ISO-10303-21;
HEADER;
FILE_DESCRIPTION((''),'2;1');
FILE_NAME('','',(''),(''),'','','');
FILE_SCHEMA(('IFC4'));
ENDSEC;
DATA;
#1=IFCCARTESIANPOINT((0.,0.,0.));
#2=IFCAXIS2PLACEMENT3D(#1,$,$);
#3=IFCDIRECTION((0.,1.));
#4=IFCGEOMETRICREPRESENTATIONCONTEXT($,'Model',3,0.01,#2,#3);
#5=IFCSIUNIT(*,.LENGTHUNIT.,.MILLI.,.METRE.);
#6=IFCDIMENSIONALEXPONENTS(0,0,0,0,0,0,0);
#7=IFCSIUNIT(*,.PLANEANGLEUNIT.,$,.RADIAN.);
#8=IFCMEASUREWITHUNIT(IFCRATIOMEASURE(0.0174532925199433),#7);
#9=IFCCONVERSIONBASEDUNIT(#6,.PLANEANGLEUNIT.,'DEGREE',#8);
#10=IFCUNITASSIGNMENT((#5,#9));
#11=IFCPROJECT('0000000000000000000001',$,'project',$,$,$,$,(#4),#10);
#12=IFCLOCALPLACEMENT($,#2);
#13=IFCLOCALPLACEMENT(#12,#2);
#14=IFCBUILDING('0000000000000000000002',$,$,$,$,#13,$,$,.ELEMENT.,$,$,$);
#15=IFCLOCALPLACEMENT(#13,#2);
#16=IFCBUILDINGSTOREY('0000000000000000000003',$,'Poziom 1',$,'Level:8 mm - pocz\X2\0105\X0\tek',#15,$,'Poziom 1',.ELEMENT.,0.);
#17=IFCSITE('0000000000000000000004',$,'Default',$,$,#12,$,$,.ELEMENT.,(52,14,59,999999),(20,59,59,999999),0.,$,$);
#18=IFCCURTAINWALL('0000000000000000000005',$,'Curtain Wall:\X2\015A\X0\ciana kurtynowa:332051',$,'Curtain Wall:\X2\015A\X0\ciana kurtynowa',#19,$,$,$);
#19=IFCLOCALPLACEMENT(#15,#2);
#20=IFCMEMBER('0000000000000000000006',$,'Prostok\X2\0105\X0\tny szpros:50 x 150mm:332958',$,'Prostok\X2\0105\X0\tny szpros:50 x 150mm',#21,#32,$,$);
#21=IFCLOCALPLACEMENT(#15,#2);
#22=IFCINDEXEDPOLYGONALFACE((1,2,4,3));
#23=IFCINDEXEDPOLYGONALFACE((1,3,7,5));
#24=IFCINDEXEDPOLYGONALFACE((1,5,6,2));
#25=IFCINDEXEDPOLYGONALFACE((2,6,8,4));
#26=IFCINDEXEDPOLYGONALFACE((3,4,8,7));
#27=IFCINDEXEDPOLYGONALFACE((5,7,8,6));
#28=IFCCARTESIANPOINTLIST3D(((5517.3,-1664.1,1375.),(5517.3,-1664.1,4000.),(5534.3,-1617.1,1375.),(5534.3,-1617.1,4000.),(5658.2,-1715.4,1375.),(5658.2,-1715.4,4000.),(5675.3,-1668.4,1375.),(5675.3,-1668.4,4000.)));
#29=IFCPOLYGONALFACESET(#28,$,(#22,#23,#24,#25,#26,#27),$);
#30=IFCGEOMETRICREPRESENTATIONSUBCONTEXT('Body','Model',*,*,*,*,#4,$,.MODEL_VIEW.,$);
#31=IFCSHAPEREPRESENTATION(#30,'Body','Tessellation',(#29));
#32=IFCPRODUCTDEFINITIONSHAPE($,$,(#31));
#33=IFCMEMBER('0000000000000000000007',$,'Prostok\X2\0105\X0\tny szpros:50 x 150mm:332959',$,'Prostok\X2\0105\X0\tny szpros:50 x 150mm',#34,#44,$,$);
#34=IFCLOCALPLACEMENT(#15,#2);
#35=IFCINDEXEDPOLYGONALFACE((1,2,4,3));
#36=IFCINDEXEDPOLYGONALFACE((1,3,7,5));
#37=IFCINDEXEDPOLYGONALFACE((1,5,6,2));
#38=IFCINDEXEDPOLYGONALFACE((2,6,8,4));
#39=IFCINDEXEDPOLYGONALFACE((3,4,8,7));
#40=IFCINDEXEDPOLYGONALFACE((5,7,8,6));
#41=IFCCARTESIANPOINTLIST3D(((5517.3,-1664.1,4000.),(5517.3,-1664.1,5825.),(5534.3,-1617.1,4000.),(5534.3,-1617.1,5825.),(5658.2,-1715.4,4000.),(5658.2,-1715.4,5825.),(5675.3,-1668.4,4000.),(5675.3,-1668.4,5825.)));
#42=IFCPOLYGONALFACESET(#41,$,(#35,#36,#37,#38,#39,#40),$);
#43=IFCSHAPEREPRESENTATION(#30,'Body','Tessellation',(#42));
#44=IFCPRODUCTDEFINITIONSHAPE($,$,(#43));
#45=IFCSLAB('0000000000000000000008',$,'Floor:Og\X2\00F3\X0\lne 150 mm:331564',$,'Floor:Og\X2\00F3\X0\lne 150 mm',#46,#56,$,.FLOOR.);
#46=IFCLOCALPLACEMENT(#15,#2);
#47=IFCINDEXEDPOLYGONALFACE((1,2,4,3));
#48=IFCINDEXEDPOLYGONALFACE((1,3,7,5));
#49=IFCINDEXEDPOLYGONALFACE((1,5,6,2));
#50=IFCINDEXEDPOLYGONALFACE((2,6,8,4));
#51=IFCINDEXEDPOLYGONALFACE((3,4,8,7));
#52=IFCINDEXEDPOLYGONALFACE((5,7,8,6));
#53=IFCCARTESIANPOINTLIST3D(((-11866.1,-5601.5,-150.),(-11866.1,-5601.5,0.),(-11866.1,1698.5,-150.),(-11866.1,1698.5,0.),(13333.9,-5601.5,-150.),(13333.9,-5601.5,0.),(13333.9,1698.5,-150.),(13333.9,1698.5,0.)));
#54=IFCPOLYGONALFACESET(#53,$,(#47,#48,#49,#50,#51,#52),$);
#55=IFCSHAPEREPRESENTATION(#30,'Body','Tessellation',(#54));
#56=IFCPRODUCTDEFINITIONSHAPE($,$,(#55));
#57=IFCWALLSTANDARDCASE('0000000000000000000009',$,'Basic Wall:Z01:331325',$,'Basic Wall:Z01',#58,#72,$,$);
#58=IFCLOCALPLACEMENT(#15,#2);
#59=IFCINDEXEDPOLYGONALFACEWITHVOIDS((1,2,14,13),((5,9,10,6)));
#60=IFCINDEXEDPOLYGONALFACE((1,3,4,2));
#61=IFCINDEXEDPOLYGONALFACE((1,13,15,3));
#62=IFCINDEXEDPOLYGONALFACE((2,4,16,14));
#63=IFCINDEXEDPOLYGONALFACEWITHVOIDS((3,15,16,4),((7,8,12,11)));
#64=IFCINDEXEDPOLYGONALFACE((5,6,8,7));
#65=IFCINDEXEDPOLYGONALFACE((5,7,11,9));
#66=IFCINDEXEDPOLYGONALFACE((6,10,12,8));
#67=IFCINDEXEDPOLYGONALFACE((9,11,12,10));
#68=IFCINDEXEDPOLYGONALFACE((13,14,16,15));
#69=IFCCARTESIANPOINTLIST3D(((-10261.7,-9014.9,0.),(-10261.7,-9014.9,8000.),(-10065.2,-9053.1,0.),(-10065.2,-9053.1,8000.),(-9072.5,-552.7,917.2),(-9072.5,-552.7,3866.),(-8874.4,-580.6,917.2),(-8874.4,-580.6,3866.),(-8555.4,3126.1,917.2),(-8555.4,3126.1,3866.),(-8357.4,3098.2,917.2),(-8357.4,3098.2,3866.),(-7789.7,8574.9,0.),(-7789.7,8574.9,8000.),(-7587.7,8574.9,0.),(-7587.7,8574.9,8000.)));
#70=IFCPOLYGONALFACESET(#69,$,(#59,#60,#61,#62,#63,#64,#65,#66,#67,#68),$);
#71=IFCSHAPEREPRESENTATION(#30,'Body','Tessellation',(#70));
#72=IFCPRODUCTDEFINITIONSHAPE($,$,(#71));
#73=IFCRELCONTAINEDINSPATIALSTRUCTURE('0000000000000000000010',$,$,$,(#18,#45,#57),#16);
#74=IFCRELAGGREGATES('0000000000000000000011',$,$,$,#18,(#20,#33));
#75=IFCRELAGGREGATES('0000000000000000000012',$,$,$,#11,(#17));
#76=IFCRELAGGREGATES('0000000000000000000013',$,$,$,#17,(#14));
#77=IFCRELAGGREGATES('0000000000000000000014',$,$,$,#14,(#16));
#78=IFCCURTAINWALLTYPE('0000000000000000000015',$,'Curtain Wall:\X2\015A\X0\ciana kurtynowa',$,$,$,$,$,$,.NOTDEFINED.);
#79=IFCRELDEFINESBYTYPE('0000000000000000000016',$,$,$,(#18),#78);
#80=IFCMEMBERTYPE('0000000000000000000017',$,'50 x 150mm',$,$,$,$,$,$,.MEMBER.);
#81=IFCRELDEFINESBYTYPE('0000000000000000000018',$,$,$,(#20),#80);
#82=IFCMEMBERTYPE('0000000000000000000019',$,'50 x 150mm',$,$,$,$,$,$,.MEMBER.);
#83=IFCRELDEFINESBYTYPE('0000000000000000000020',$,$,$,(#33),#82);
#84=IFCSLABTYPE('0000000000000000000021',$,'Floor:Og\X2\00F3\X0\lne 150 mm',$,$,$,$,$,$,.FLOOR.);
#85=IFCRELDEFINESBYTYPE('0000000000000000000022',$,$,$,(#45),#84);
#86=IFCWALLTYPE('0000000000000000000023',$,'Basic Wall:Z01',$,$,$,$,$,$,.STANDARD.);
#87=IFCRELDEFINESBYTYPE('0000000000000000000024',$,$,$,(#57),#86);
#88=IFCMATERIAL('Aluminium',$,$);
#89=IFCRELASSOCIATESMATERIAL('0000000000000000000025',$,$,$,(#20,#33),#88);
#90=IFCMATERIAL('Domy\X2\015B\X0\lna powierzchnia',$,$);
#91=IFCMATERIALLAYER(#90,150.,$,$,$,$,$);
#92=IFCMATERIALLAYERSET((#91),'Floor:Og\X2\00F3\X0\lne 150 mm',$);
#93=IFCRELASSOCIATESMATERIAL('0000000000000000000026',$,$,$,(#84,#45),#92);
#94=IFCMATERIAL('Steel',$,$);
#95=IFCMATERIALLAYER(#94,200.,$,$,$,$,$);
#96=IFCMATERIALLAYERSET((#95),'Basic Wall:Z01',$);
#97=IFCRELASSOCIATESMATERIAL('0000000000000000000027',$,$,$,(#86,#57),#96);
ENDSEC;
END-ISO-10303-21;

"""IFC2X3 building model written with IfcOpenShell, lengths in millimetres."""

from ifc_helpers import new_model, entity, si_unit, converted_unit, direction, frame, frame_2d, origin, origin_2d_with_axis, place, context, subcontext, project, spatial, polyline, rectangle, outline, extrude, source, transform, mapped, material, layer, layer_set, layer_usage, type_object, type_shapes, element, aggregate, save


model = new_model("IFC2X3")

# Units and contexts
model_context = context("Model", 3, precision=0.01, world=origin(), true_north=direction((0.0, 1.0)))
body_context = subcontext(model_context, "Body", "Model", "MODEL_VIEW")
ifc_project = project(units=[si_unit("LENGTHUNIT", "METRE", prefix="MILLI"), converted_unit("PLANEANGLEUNIT", "DEGREE", entity("IfcRatioMeasure", 0.0174532925199433), si_unit("PLANEANGLEUNIT", "RADIAN"), dimensions=[0, 0, 0, 0, 0, 0, 0])], contexts=[model_context])

# Site, building, storey
site_placement = place(None, origin())
site = spatial("IfcSite", under=ifc_project, at=site_placement, Name="Default", CompositionType="ELEMENT", RefLatitude=(52, 14, 59, 999999), RefLongitude=(20, 59, 59, 999999), RefElevation=0.0)
building_placement = place(site_placement, origin())
building = spatial("IfcBuilding", under=site, at=building_placement, CompositionType="ELEMENT")
storey_placement = place(building_placement, origin())
storey = spatial("IfcBuildingStorey", under=building, at=storey_placement, Name="Poziom 1", ObjectType="Level:8 mm - początek", LongName="Poziom 1", CompositionType="ELEMENT", Elevation=0.0)

# Curtain wall, members
curtain_wall_type = type_object("IfcCurtainWallType", Name="Curtain Wall:Ściana kurtynowa", PredefinedType="NOTDEFINED")
curtain_wall_placement = place(storey_placement, origin())
curtain_wall = element("IfcCurtainWall", 1, at=curtain_wall_placement, inside=storey, type_object=curtain_wall_type, Name="Curtain Wall:Ściana kurtynowa:332051", ObjectType="Curtain Wall:Ściana kurtynowa")
ifc_material_1 = material(Name="Aluminium")
member_type_1 = type_object("IfcMemberType", Name="50 x 150mm", PredefinedType="MEMBER")
shared_shape_1 = source(origin(), body_context, "Body", "SweptSolid", [
    extrude(rectangle(XDim=150.0, YDim=50.0, at=origin_2d_with_axis()), frame((0.0, 0.0, -2625.0), z_axis=(0.0, 0.0, 1.0), x_axis=(0.0, -1.0, 0.0)), (0.0, 0.0, 1.0), 2625.0),
])
type_shapes(member_type_1, [shared_shape_1])
member_1_placement = place(storey_placement, frame((5596.3, -1666.3, 1375.0), z_axis=(0.0, 0.0, -1.0), x_axis=(0.341586, 0.939851, 0.0)))
member_1 = element("IfcMember", 2, at=member_1_placement, type_object=member_type_1, material=ifc_material_1, Name="Prostokątny szpros:50 x 150mm:332958", ObjectType="Prostokątny szpros:50 x 150mm", context=body_context, shape_type="MappedRepresentation", body=[
    mapped(shared_shape_1, transform((0.0, 0.0, 0.0), scale=1.0)),
])
member_type_2 = type_object("IfcMemberType", Name="50 x 150mm", PredefinedType="MEMBER")
shared_shape_2 = source(origin(), body_context, "Body", "SweptSolid", [
    extrude(rectangle(XDim=150.0, YDim=50.0, at=origin_2d_with_axis()), frame((0.0, 0.0, -1825.0), z_axis=(0.0, 0.0, 1.0), x_axis=(0.0, -1.0, 0.0)), (0.0, 0.0, 1.0), 1825.0),
])
type_shapes(member_type_2, [shared_shape_2])
member_2_placement = place(storey_placement, frame((5596.3, -1666.3, 4000.0), z_axis=(0.0, 0.0, -1.0), x_axis=(0.341586, 0.939851, 0.0)))
member_2 = element("IfcMember", 3, at=member_2_placement, type_object=member_type_2, material=ifc_material_1, Name="Prostokątny szpros:50 x 150mm:332959", ObjectType="Prostokątny szpros:50 x 150mm", context=body_context, shape_type="MappedRepresentation", body=[
    mapped(shared_shape_2, transform((0.0, 0.0, 0.0), scale=1.0)),
])

# Slab
ifc_material_2 = material(Name="Domyślna powierzchnia")
ifc_layer_1 = layer(ifc_material_2, 150.0)
ifc_layer_set_1 = layer_set([ifc_layer_1], Name="Floor:Ogólne 150 mm")
ifc_layer_usage_1 = layer_usage(ifc_layer_set_1, "AXIS3", "POSITIVE", 0.0)
slab_type = type_object("IfcSlabType", Name="Floor:Ogólne 150 mm", PredefinedType="FLOOR", material=ifc_layer_set_1)
slab_placement = place(storey_placement, origin())
element("IfcSlab", 4, at=slab_placement, inside=storey, type_object=slab_type, material=ifc_layer_usage_1, Name="Floor:Ogólne 150 mm:331564", ObjectType="Floor:Ogólne 150 mm", PredefinedType="FLOOR", context=body_context, shape_type="SweptSolid", body=[
    extrude(rectangle(XDim=7300.0, YDim=25200.0, at=frame_2d((0.0, 0.0), x_axis=(1.0, 0.0))), frame((733.9, -1951.5, 0.0), z_axis=(0.0, 0.0, -1.0), x_axis=(0.0, 1.0, 0.0)), (0.0, 0.0, 1.0), 150.0),
])

aggregate(curtain_wall, [member_1, member_2])

# Wall, opening
ifc_material_3 = material(Name="Steel")
ifc_layer_2 = layer(ifc_material_3, 200.0)
ifc_layer_set_2 = layer_set([ifc_layer_2], Name="Basic Wall:Z01")
ifc_layer_usage_2 = layer_usage(ifc_layer_set_2, "AXIS2", "NEGATIVE", 100.0)
wall_type = type_object("IfcWallType", Name="Basic Wall:Z01", PredefinedType="STANDARD", material=ifc_layer_set_2)
wall_1_placement = place(storey_placement, frame((-7686.7, 8588.8, 0.0), z_axis=(0.0, 0.0, 1.0), x_axis=(-0.139173, -0.990268, 0.0)))
wall_1 = element("IfcWallStandardCase", 5, at=wall_1_placement, inside=storey, type_object=wall_type, material=ifc_layer_usage_2, Name="Basic Wall:Z01:331325", ObjectType="Basic Wall:Z01", context=body_context, shape_type="SweptSolid", body=[
    extrude(outline(polyline([(17790.8, -100.0), (17801.2, 100.0), (17300.6, 100.0), (504.9, 100.0), (0.0, 100.0), (28.1, -100.0), (17790.8, -100.0)])), origin(), (0.0, 0.0, 1.0), 8000.0),
])
opening_1_placement = place(wall_1_placement, origin())
element("IfcOpeningElement", 6, at=opening_1_placement, cuts=wall_1, ObjectType="Opening", context=body_context, shape_type="SweptSolid", body=[
    extrude(rectangle(XDim=2948.8, YDim=3715.0, at=origin_2d_with_axis()), frame((7387.9, -100.0, 2391.6), z_axis=(0.0, 1.0, 0.0), x_axis=(0.0, 0.0, -1.0)), (0.0, 0.0, 1.0), 200.0),
])

save(model, "model.ifc")
